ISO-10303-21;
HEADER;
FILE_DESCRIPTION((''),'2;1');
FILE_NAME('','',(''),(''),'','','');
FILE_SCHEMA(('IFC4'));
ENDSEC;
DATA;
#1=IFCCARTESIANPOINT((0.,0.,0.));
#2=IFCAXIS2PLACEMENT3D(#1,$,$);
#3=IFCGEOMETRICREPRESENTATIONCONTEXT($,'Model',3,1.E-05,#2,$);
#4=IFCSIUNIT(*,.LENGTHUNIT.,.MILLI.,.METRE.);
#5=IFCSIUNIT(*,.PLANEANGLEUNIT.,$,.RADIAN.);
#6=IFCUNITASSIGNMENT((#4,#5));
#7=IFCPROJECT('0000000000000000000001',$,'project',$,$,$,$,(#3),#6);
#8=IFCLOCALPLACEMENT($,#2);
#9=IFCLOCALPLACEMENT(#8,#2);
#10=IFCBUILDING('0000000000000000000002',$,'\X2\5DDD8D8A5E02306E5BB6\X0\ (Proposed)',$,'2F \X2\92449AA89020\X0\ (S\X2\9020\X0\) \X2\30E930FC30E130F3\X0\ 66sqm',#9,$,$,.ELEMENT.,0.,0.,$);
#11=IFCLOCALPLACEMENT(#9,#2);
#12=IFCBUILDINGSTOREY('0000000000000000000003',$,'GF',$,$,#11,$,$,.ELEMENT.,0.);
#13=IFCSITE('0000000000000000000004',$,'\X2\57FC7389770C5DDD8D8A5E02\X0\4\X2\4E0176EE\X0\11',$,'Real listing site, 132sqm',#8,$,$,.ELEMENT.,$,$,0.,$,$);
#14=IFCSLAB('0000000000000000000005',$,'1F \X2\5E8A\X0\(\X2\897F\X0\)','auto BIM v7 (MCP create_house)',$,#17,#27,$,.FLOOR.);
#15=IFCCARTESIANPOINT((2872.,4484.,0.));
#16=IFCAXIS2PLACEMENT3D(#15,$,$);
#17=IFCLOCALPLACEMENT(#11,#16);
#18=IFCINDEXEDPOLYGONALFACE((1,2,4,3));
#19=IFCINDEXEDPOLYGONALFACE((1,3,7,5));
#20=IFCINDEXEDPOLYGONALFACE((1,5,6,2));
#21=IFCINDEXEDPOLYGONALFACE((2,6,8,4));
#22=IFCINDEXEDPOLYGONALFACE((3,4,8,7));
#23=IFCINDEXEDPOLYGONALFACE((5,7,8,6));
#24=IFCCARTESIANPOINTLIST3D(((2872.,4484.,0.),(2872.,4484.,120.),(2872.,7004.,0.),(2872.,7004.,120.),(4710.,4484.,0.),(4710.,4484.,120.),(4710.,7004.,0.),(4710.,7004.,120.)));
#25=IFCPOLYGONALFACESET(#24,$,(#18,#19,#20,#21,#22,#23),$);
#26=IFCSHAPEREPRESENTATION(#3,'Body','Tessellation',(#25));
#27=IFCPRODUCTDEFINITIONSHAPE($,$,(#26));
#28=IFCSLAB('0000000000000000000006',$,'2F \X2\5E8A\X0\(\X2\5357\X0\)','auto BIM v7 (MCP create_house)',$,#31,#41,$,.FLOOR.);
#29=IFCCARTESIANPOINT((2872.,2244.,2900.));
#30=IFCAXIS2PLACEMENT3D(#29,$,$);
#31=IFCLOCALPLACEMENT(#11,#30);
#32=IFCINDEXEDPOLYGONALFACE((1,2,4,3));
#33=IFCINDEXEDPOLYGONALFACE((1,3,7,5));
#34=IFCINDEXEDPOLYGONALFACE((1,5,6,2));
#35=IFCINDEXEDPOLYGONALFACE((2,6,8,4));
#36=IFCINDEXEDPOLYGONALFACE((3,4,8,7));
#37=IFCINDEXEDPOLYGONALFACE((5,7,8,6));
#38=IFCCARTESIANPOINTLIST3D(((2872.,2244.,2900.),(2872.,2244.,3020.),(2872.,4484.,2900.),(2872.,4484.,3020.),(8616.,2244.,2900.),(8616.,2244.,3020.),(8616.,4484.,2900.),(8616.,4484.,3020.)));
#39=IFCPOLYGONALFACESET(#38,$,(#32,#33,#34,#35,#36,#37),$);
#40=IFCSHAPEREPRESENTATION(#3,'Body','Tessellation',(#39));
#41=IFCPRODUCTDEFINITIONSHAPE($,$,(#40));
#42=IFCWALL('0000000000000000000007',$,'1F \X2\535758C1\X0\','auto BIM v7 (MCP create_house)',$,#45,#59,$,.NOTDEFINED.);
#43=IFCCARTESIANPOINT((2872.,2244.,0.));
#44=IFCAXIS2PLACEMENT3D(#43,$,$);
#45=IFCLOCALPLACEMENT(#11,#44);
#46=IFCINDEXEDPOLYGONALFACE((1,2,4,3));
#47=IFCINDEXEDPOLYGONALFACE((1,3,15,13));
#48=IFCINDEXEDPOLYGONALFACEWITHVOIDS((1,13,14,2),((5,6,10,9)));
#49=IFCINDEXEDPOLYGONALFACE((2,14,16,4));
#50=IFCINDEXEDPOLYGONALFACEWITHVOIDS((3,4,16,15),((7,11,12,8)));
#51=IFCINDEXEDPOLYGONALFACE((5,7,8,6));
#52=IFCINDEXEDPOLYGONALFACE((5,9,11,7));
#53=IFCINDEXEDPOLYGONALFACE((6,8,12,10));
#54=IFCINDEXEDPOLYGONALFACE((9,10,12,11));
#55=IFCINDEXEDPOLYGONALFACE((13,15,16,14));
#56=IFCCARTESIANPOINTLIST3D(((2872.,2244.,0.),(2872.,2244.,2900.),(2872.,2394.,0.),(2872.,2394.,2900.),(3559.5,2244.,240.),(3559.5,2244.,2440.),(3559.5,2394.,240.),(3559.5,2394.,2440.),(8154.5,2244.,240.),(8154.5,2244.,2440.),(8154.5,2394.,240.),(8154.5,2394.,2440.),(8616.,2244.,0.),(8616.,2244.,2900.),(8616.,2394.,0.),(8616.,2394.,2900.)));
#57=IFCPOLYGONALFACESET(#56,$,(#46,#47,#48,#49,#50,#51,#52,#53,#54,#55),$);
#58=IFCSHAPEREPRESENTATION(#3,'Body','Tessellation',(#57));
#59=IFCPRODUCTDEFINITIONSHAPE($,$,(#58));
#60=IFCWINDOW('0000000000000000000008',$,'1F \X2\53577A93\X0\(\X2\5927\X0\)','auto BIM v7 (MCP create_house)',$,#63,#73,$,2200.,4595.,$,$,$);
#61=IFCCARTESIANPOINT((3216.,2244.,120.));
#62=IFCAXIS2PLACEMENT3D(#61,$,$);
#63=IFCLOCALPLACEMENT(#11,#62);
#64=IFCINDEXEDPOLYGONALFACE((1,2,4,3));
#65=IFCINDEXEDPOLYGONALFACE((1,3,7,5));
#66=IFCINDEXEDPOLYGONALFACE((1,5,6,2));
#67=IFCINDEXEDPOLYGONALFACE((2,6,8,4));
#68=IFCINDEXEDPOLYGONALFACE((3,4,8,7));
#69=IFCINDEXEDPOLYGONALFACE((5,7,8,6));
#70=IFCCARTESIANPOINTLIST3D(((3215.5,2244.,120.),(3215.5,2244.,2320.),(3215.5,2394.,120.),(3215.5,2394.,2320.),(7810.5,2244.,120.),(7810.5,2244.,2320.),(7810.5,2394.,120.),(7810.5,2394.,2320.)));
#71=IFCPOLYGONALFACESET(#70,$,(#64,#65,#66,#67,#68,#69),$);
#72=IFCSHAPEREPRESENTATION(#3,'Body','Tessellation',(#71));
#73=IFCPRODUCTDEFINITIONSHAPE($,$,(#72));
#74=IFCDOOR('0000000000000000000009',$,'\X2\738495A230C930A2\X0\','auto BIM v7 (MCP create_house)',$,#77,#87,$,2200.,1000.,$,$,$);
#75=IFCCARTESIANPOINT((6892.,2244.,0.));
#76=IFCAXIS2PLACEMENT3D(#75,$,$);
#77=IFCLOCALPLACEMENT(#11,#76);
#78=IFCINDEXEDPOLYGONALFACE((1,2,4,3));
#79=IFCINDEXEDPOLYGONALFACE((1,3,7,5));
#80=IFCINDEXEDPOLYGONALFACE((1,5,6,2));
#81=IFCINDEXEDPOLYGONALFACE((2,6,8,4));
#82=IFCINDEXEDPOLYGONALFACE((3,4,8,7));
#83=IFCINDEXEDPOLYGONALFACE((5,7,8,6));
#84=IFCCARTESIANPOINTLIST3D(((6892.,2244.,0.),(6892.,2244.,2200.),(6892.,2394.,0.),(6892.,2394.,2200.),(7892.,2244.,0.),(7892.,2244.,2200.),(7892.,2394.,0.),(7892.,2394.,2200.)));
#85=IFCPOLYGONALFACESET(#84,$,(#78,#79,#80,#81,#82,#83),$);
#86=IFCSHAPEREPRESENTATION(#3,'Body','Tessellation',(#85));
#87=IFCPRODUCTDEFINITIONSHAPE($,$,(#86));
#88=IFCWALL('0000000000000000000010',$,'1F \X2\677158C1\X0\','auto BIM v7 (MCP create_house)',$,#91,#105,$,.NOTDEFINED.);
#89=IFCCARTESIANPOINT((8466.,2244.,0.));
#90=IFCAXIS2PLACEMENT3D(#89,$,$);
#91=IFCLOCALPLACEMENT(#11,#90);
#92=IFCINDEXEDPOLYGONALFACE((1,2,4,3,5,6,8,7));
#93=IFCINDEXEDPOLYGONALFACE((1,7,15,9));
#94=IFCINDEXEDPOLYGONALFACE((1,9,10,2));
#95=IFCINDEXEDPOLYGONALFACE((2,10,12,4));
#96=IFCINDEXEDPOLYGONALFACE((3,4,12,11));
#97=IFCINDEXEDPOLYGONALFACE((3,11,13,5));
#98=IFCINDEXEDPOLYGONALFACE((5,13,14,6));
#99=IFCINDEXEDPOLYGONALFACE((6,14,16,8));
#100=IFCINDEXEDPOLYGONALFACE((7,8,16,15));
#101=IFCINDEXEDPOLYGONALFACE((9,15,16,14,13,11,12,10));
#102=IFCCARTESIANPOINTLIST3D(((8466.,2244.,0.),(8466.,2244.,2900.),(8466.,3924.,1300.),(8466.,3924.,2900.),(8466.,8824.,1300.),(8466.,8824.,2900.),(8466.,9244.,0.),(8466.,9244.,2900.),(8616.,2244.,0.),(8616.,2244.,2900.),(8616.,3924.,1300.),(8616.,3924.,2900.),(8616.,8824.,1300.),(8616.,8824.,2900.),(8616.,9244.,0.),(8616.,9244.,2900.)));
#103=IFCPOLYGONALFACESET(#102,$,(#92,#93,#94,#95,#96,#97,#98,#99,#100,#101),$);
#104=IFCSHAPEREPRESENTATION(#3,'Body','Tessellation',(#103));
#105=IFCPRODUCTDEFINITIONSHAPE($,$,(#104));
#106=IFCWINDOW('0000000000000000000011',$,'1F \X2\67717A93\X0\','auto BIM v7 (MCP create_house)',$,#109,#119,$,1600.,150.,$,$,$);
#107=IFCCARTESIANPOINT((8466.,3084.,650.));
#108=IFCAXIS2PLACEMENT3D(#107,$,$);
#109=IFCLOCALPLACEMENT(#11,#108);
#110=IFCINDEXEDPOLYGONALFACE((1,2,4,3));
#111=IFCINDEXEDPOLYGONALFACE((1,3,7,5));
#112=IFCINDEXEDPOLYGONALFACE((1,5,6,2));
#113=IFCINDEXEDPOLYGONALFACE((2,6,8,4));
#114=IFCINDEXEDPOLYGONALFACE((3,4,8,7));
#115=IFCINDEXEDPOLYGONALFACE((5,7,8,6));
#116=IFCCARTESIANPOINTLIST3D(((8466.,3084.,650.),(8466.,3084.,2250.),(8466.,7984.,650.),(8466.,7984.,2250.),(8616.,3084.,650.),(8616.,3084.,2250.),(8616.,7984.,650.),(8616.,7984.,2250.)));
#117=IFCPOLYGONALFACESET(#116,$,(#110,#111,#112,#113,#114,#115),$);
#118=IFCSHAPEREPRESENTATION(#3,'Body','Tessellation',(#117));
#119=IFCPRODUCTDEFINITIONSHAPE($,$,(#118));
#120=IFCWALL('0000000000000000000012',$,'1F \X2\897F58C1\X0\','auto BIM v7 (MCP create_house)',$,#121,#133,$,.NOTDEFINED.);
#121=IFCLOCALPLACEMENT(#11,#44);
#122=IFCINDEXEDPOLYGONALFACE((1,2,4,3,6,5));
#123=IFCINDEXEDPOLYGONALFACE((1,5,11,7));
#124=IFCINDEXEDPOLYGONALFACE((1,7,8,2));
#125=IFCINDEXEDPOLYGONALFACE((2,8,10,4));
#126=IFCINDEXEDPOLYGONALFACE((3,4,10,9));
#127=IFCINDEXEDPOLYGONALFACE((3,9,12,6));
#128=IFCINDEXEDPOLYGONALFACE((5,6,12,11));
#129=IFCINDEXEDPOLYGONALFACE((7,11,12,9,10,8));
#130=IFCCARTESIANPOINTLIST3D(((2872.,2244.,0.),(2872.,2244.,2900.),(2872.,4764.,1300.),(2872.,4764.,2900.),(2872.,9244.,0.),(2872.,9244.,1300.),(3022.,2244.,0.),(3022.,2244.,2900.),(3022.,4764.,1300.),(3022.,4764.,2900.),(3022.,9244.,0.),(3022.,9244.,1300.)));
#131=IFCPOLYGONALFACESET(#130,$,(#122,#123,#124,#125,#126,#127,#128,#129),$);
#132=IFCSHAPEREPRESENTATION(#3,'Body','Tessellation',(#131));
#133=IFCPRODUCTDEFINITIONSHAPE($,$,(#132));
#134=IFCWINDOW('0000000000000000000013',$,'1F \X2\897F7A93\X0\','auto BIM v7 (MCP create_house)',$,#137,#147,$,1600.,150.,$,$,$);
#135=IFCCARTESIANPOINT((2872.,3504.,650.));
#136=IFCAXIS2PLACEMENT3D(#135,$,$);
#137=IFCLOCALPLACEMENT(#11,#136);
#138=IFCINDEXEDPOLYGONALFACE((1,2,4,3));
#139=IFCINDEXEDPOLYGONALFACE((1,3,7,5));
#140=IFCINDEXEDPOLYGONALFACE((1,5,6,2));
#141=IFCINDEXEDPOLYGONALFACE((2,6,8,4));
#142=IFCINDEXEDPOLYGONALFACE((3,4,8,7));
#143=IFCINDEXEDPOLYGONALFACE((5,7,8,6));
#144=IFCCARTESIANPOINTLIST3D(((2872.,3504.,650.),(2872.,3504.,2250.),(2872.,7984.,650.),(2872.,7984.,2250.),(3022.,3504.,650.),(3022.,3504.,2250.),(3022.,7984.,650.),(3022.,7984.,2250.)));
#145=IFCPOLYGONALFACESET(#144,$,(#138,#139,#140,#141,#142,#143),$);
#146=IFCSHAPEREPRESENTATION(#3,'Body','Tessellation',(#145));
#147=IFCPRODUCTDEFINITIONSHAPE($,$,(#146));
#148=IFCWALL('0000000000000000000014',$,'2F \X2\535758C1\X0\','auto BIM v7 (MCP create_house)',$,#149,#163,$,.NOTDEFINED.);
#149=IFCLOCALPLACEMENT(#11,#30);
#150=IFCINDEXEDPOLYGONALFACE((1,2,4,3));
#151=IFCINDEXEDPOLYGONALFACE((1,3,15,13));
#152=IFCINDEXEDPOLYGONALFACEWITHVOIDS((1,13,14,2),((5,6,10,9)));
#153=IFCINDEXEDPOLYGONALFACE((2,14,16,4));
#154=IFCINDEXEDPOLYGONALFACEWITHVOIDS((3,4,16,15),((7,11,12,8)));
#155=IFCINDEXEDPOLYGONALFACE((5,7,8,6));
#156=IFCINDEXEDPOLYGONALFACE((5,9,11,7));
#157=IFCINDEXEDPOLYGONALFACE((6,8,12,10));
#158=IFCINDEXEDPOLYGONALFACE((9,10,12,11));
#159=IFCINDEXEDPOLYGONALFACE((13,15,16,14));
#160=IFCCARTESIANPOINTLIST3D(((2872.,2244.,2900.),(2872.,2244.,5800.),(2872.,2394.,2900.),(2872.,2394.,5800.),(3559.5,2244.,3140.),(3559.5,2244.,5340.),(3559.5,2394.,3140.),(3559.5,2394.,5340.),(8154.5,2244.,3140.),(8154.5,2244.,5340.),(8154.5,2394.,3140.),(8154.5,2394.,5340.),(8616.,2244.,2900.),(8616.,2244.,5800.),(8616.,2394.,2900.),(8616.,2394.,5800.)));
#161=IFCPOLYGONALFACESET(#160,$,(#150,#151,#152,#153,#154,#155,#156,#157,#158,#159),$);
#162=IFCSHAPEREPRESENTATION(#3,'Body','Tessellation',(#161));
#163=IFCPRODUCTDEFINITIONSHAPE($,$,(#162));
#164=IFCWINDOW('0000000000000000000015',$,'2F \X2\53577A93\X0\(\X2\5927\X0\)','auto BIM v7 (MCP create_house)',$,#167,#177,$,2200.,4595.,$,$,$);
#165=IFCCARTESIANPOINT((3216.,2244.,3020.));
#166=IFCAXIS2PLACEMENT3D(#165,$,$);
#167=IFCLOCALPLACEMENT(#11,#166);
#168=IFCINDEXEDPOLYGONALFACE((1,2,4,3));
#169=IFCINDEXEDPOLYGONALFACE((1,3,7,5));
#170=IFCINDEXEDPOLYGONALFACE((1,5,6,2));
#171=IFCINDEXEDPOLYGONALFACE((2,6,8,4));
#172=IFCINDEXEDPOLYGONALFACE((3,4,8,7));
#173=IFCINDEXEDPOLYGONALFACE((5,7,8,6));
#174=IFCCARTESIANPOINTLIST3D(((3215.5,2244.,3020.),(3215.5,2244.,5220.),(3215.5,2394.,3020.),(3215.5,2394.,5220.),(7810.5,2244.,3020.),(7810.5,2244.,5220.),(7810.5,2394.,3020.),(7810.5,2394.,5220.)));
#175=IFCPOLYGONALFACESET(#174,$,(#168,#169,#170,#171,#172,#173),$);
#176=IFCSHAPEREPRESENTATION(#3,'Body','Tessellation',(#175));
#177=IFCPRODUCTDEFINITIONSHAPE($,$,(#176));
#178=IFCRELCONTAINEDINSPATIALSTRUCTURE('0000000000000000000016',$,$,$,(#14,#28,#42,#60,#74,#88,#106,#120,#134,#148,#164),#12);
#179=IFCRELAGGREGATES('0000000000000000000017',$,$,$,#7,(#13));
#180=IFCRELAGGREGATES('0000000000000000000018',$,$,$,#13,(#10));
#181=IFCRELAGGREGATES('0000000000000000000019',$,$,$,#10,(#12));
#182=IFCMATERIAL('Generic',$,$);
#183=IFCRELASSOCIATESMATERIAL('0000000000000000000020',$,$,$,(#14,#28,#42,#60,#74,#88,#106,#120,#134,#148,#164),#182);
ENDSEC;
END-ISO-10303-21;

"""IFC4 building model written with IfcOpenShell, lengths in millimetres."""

from ifc_helpers import new_model, si_unit, frame, frame_2d, origin, place, context, project, spatial, rectangle, extrude, material, element, fill, save


model = new_model("IFC4")

# Units and contexts
model_context = context("Model", 3, precision=1e-05, world=origin())
ifc_project = project(units=[si_unit("LENGTHUNIT", "METRE", prefix="MILLI"), si_unit("PLANEANGLEUNIT", "RADIAN")], contexts=[model_context])

# Site, building, storey
site_placement = place(None, origin())
site = spatial("IfcSite", under=ifc_project, at=site_placement, Name="埼玉県川越市4丁目11", ObjectType="Real listing site, 132sqm", CompositionType="ELEMENT", RefElevation=0.0)
building_placement = place(site_placement, origin())
building = spatial("IfcBuilding", under=site, at=building_placement, Name="川越市の家 (Proposed)", ObjectType="2F 鉄骨造 (S造) ラーメン 66sqm", CompositionType="ELEMENT", ElevationOfRefHeight=0.0, ElevationOfTerrain=0.0)
storey_placement = place(building_placement, origin())
storey = spatial("IfcBuildingStorey", under=building, at=storey_placement, Name="GF", CompositionType="ELEMENT", Elevation=0.0)

# Slabs
ifc_material = material(Name="Generic")
slab_1_placement = place(storey_placement, frame((2872.0, 4484.0, 0.0)))
element("IfcSlab", 1, at=slab_1_placement, inside=storey, material=ifc_material, Name="1F 床(西)", Description="auto BIM v7 (MCP create_house)", PredefinedType="FLOOR", context=model_context, shape_type="SweptSolid", body=[
    extrude(rectangle(XDim=1838.0, YDim=2520.0, at=frame_2d((919.0, 1260.0))), frame((2872.0, 4484.0, 0.0)), (0.0, 0.0, 1.0), 120.0),
])
slab_2_placement = place(storey_placement, frame((2872.0, 2244.0, 2900.0)))
element("IfcSlab", 2, at=slab_2_placement, inside=storey, material=ifc_material, Name="2F 床(南)", Description="auto BIM v7 (MCP create_house)", PredefinedType="FLOOR", context=model_context, shape_type="SweptSolid", body=[
    extrude(rectangle(XDim=5744.0, YDim=2240.0, at=frame_2d((2872.0, 1120.0))), frame((2872.0, 2244.0, 2900.0)), (0.0, 0.0, 1.0), 120.0),
])

# Wall, openings, window, door
wall_1_placement = place(storey_placement, frame((2872.0, 2244.0, 0.0)))
wall_1 = element("IfcWall", 3, at=wall_1_placement, inside=storey, material=ifc_material, Name="1F 南壁", Description="auto BIM v7 (MCP create_house)", PredefinedType="NOTDEFINED", context=model_context, shape_type="SweptSolid", body=[
    extrude(rectangle(XDim=5744.0, YDim=150.0, at=frame_2d((2872.0, 75.0))), frame((2872.0, 2244.0, 0.0)), (0.0, 0.0, 1.0), 2900.0),
])
opening_1_placement = place(storey_placement, frame((3216.0, 2244.0, 120.0)))
opening_1 = element("IfcOpeningElement", 4, at=opening_1_placement, cuts=wall_1, PredefinedType="NOTDEFINED", context=model_context, shape_type="SweptSolid", body=[
    extrude(rectangle(XDim=4595.0, YDim=150.0, at=frame_2d((2297.0, 75.0))), frame((3216.0, 2244.0, 120.0)), (0.0, 0.0, 1.0), 2200.0),
])
opening_2_placement = place(storey_placement, frame((6892.0, 2244.0, 0.0)))
opening_2 = element("IfcOpeningElement", 5, at=opening_2_placement, cuts=wall_1, PredefinedType="NOTDEFINED", context=model_context, shape_type="SweptSolid", body=[
    extrude(rectangle(XDim=1000.0, YDim=150.0, at=frame_2d((500.0, 75.0))), frame((6892.0, 2244.0, 0.0)), (0.0, 0.0, 1.0), 2200.0),
])
window_1_placement = place(storey_placement, frame((3216.0, 2244.0, 120.0)))
window_1 = element("IfcWindow", 6, at=window_1_placement, inside=storey, material=ifc_material, Name="1F 南窓(大)", Description="auto BIM v7 (MCP create_house)", OverallHeight=2200.0, OverallWidth=4595.0, context=model_context, shape_type="SweptSolid", body=[
    extrude(rectangle(XDim=4595.0, YDim=150.0, at=frame_2d((2297.0, 75.0))), frame((3216.0, 2244.0, 120.0)), (0.0, 0.0, 1.0), 2200.0),
])
fill(opening_1, window_1)
door_placement = place(storey_placement, frame((6892.0, 2244.0, 0.0)))
door = element("IfcDoor", 7, at=door_placement, inside=storey, material=ifc_material, Name="玄関ドア", Description="auto BIM v7 (MCP create_house)", OverallHeight=2200.0, OverallWidth=1000.0, context=model_context, shape_type="SweptSolid", body=[
    extrude(rectangle(XDim=1000.0, YDim=150.0, at=frame_2d((500.0, 75.0))), frame((6892.0, 2244.0, 0.0)), (0.0, 0.0, 1.0), 2200.0),
])
fill(opening_2, door)

# Walls, openings, windows
wall_2_placement = place(storey_placement, frame((8466.0, 2244.0, 0.0)))
wall_2 = element("IfcWall", 8, at=wall_2_placement, inside=storey, material=ifc_material, Name="1F 東壁", Description="auto BIM v7 (MCP create_house)", PredefinedType="NOTDEFINED", context=model_context, shape_type="SweptSolid", body=[
    extrude(rectangle(XDim=150.0, YDim=7000.0, at=frame_2d((75.0, 3500.0))), frame((8466.0, 2244.0, 0.0)), (0.0, 0.0, 1.0), 2900.0),
])
opening_3_placement = place(storey_placement, frame((8466.0, 3084.0, 650.0)))
opening_3 = element("IfcOpeningElement", 9, at=opening_3_placement, cuts=wall_2, PredefinedType="NOTDEFINED", context=model_context, shape_type="SweptSolid", body=[
    extrude(rectangle(XDim=150.0, YDim=4900.0, at=frame_2d((75.0, 2450.0))), frame((8466.0, 3084.0, 650.0)), (0.0, 0.0, 1.0), 1600.0),
])
window_2_placement = place(storey_placement, frame((8466.0, 3084.0, 650.0)))
window_2 = element("IfcWindow", 10, at=window_2_placement, inside=storey, material=ifc_material, Name="1F 東窓", Description="auto BIM v7 (MCP create_house)", OverallHeight=1600.0, OverallWidth=150.0, context=model_context, shape_type="SweptSolid", body=[
    extrude(rectangle(XDim=150.0, YDim=4900.0, at=frame_2d((75.0, 2450.0))), frame((8466.0, 3084.0, 650.0)), (0.0, 0.0, 1.0), 1600.0),
])
fill(opening_3, window_2)
wall_3_placement = place(storey_placement, frame((2872.0, 2244.0, 0.0)))
wall_3 = element("IfcWall", 11, at=wall_3_placement, inside=storey, material=ifc_material, Name="1F 西壁", Description="auto BIM v7 (MCP create_house)", PredefinedType="NOTDEFINED", context=model_context, shape_type="SweptSolid", body=[
    extrude(rectangle(XDim=150.0, YDim=7000.0, at=frame_2d((75.0, 3500.0))), frame((2872.0, 2244.0, 0.0)), (0.0, 0.0, 1.0), 2900.0),
])
opening_4_placement = place(storey_placement, frame((2872.0, 3504.0, 650.0)))
opening_4 = element("IfcOpeningElement", 12, at=opening_4_placement, cuts=wall_3, PredefinedType="NOTDEFINED", context=model_context, shape_type="SweptSolid", body=[
    extrude(rectangle(XDim=150.0, YDim=4480.0, at=frame_2d((75.0, 2240.0))), frame((2872.0, 3504.0, 650.0)), (0.0, 0.0, 1.0), 1600.0),
])
window_3_placement = place(storey_placement, frame((2872.0, 3504.0, 650.0)))
window_3 = element("IfcWindow", 13, at=window_3_placement, inside=storey, material=ifc_material, Name="1F 西窓", Description="auto BIM v7 (MCP create_house)", OverallHeight=1600.0, OverallWidth=150.0, context=model_context, shape_type="SweptSolid", body=[
    extrude(rectangle(XDim=150.0, YDim=4480.0, at=frame_2d((75.0, 2240.0))), frame((2872.0, 3504.0, 650.0)), (0.0, 0.0, 1.0), 1600.0),
])
fill(opening_4, window_3)

# Wall, opening, window
wall_4_placement = place(storey_placement, frame((2872.0, 2244.0, 2900.0)))
wall_4 = element("IfcWall", 14, at=wall_4_placement, inside=storey, material=ifc_material, Name="2F 南壁", Description="auto BIM v7 (MCP create_house)", PredefinedType="NOTDEFINED", context=model_context, shape_type="SweptSolid", body=[
    extrude(rectangle(XDim=5744.0, YDim=150.0, at=frame_2d((2872.0, 75.0))), frame((2872.0, 2244.0, 2900.0)), (0.0, 0.0, 1.0), 2900.0),
])
opening_5_placement = place(storey_placement, frame((3216.0, 2244.0, 3020.0)))
opening_5 = element("IfcOpeningElement", 15, at=opening_5_placement, cuts=wall_4, PredefinedType="NOTDEFINED", context=model_context, shape_type="SweptSolid", body=[
    extrude(rectangle(XDim=4595.0, YDim=150.0, at=frame_2d((2297.0, 75.0))), frame((3216.0, 2244.0, 3020.0)), (0.0, 0.0, 1.0), 2200.0),
])
window_4_placement = place(storey_placement, frame((3216.0, 2244.0, 3020.0)))
window_4 = element("IfcWindow", 16, at=window_4_placement, inside=storey, material=ifc_material, Name="2F 南窓(大)", Description="auto BIM v7 (MCP create_house)", OverallHeight=2200.0, OverallWidth=4595.0, context=model_context, shape_type="SweptSolid", body=[
    extrude(rectangle(XDim=4595.0, YDim=150.0, at=frame_2d((2297.0, 75.0))), frame((3216.0, 2244.0, 3020.0)), (0.0, 0.0, 1.0), 2200.0),
])
fill(opening_5, window_4)

save(model, "model.ifc")
